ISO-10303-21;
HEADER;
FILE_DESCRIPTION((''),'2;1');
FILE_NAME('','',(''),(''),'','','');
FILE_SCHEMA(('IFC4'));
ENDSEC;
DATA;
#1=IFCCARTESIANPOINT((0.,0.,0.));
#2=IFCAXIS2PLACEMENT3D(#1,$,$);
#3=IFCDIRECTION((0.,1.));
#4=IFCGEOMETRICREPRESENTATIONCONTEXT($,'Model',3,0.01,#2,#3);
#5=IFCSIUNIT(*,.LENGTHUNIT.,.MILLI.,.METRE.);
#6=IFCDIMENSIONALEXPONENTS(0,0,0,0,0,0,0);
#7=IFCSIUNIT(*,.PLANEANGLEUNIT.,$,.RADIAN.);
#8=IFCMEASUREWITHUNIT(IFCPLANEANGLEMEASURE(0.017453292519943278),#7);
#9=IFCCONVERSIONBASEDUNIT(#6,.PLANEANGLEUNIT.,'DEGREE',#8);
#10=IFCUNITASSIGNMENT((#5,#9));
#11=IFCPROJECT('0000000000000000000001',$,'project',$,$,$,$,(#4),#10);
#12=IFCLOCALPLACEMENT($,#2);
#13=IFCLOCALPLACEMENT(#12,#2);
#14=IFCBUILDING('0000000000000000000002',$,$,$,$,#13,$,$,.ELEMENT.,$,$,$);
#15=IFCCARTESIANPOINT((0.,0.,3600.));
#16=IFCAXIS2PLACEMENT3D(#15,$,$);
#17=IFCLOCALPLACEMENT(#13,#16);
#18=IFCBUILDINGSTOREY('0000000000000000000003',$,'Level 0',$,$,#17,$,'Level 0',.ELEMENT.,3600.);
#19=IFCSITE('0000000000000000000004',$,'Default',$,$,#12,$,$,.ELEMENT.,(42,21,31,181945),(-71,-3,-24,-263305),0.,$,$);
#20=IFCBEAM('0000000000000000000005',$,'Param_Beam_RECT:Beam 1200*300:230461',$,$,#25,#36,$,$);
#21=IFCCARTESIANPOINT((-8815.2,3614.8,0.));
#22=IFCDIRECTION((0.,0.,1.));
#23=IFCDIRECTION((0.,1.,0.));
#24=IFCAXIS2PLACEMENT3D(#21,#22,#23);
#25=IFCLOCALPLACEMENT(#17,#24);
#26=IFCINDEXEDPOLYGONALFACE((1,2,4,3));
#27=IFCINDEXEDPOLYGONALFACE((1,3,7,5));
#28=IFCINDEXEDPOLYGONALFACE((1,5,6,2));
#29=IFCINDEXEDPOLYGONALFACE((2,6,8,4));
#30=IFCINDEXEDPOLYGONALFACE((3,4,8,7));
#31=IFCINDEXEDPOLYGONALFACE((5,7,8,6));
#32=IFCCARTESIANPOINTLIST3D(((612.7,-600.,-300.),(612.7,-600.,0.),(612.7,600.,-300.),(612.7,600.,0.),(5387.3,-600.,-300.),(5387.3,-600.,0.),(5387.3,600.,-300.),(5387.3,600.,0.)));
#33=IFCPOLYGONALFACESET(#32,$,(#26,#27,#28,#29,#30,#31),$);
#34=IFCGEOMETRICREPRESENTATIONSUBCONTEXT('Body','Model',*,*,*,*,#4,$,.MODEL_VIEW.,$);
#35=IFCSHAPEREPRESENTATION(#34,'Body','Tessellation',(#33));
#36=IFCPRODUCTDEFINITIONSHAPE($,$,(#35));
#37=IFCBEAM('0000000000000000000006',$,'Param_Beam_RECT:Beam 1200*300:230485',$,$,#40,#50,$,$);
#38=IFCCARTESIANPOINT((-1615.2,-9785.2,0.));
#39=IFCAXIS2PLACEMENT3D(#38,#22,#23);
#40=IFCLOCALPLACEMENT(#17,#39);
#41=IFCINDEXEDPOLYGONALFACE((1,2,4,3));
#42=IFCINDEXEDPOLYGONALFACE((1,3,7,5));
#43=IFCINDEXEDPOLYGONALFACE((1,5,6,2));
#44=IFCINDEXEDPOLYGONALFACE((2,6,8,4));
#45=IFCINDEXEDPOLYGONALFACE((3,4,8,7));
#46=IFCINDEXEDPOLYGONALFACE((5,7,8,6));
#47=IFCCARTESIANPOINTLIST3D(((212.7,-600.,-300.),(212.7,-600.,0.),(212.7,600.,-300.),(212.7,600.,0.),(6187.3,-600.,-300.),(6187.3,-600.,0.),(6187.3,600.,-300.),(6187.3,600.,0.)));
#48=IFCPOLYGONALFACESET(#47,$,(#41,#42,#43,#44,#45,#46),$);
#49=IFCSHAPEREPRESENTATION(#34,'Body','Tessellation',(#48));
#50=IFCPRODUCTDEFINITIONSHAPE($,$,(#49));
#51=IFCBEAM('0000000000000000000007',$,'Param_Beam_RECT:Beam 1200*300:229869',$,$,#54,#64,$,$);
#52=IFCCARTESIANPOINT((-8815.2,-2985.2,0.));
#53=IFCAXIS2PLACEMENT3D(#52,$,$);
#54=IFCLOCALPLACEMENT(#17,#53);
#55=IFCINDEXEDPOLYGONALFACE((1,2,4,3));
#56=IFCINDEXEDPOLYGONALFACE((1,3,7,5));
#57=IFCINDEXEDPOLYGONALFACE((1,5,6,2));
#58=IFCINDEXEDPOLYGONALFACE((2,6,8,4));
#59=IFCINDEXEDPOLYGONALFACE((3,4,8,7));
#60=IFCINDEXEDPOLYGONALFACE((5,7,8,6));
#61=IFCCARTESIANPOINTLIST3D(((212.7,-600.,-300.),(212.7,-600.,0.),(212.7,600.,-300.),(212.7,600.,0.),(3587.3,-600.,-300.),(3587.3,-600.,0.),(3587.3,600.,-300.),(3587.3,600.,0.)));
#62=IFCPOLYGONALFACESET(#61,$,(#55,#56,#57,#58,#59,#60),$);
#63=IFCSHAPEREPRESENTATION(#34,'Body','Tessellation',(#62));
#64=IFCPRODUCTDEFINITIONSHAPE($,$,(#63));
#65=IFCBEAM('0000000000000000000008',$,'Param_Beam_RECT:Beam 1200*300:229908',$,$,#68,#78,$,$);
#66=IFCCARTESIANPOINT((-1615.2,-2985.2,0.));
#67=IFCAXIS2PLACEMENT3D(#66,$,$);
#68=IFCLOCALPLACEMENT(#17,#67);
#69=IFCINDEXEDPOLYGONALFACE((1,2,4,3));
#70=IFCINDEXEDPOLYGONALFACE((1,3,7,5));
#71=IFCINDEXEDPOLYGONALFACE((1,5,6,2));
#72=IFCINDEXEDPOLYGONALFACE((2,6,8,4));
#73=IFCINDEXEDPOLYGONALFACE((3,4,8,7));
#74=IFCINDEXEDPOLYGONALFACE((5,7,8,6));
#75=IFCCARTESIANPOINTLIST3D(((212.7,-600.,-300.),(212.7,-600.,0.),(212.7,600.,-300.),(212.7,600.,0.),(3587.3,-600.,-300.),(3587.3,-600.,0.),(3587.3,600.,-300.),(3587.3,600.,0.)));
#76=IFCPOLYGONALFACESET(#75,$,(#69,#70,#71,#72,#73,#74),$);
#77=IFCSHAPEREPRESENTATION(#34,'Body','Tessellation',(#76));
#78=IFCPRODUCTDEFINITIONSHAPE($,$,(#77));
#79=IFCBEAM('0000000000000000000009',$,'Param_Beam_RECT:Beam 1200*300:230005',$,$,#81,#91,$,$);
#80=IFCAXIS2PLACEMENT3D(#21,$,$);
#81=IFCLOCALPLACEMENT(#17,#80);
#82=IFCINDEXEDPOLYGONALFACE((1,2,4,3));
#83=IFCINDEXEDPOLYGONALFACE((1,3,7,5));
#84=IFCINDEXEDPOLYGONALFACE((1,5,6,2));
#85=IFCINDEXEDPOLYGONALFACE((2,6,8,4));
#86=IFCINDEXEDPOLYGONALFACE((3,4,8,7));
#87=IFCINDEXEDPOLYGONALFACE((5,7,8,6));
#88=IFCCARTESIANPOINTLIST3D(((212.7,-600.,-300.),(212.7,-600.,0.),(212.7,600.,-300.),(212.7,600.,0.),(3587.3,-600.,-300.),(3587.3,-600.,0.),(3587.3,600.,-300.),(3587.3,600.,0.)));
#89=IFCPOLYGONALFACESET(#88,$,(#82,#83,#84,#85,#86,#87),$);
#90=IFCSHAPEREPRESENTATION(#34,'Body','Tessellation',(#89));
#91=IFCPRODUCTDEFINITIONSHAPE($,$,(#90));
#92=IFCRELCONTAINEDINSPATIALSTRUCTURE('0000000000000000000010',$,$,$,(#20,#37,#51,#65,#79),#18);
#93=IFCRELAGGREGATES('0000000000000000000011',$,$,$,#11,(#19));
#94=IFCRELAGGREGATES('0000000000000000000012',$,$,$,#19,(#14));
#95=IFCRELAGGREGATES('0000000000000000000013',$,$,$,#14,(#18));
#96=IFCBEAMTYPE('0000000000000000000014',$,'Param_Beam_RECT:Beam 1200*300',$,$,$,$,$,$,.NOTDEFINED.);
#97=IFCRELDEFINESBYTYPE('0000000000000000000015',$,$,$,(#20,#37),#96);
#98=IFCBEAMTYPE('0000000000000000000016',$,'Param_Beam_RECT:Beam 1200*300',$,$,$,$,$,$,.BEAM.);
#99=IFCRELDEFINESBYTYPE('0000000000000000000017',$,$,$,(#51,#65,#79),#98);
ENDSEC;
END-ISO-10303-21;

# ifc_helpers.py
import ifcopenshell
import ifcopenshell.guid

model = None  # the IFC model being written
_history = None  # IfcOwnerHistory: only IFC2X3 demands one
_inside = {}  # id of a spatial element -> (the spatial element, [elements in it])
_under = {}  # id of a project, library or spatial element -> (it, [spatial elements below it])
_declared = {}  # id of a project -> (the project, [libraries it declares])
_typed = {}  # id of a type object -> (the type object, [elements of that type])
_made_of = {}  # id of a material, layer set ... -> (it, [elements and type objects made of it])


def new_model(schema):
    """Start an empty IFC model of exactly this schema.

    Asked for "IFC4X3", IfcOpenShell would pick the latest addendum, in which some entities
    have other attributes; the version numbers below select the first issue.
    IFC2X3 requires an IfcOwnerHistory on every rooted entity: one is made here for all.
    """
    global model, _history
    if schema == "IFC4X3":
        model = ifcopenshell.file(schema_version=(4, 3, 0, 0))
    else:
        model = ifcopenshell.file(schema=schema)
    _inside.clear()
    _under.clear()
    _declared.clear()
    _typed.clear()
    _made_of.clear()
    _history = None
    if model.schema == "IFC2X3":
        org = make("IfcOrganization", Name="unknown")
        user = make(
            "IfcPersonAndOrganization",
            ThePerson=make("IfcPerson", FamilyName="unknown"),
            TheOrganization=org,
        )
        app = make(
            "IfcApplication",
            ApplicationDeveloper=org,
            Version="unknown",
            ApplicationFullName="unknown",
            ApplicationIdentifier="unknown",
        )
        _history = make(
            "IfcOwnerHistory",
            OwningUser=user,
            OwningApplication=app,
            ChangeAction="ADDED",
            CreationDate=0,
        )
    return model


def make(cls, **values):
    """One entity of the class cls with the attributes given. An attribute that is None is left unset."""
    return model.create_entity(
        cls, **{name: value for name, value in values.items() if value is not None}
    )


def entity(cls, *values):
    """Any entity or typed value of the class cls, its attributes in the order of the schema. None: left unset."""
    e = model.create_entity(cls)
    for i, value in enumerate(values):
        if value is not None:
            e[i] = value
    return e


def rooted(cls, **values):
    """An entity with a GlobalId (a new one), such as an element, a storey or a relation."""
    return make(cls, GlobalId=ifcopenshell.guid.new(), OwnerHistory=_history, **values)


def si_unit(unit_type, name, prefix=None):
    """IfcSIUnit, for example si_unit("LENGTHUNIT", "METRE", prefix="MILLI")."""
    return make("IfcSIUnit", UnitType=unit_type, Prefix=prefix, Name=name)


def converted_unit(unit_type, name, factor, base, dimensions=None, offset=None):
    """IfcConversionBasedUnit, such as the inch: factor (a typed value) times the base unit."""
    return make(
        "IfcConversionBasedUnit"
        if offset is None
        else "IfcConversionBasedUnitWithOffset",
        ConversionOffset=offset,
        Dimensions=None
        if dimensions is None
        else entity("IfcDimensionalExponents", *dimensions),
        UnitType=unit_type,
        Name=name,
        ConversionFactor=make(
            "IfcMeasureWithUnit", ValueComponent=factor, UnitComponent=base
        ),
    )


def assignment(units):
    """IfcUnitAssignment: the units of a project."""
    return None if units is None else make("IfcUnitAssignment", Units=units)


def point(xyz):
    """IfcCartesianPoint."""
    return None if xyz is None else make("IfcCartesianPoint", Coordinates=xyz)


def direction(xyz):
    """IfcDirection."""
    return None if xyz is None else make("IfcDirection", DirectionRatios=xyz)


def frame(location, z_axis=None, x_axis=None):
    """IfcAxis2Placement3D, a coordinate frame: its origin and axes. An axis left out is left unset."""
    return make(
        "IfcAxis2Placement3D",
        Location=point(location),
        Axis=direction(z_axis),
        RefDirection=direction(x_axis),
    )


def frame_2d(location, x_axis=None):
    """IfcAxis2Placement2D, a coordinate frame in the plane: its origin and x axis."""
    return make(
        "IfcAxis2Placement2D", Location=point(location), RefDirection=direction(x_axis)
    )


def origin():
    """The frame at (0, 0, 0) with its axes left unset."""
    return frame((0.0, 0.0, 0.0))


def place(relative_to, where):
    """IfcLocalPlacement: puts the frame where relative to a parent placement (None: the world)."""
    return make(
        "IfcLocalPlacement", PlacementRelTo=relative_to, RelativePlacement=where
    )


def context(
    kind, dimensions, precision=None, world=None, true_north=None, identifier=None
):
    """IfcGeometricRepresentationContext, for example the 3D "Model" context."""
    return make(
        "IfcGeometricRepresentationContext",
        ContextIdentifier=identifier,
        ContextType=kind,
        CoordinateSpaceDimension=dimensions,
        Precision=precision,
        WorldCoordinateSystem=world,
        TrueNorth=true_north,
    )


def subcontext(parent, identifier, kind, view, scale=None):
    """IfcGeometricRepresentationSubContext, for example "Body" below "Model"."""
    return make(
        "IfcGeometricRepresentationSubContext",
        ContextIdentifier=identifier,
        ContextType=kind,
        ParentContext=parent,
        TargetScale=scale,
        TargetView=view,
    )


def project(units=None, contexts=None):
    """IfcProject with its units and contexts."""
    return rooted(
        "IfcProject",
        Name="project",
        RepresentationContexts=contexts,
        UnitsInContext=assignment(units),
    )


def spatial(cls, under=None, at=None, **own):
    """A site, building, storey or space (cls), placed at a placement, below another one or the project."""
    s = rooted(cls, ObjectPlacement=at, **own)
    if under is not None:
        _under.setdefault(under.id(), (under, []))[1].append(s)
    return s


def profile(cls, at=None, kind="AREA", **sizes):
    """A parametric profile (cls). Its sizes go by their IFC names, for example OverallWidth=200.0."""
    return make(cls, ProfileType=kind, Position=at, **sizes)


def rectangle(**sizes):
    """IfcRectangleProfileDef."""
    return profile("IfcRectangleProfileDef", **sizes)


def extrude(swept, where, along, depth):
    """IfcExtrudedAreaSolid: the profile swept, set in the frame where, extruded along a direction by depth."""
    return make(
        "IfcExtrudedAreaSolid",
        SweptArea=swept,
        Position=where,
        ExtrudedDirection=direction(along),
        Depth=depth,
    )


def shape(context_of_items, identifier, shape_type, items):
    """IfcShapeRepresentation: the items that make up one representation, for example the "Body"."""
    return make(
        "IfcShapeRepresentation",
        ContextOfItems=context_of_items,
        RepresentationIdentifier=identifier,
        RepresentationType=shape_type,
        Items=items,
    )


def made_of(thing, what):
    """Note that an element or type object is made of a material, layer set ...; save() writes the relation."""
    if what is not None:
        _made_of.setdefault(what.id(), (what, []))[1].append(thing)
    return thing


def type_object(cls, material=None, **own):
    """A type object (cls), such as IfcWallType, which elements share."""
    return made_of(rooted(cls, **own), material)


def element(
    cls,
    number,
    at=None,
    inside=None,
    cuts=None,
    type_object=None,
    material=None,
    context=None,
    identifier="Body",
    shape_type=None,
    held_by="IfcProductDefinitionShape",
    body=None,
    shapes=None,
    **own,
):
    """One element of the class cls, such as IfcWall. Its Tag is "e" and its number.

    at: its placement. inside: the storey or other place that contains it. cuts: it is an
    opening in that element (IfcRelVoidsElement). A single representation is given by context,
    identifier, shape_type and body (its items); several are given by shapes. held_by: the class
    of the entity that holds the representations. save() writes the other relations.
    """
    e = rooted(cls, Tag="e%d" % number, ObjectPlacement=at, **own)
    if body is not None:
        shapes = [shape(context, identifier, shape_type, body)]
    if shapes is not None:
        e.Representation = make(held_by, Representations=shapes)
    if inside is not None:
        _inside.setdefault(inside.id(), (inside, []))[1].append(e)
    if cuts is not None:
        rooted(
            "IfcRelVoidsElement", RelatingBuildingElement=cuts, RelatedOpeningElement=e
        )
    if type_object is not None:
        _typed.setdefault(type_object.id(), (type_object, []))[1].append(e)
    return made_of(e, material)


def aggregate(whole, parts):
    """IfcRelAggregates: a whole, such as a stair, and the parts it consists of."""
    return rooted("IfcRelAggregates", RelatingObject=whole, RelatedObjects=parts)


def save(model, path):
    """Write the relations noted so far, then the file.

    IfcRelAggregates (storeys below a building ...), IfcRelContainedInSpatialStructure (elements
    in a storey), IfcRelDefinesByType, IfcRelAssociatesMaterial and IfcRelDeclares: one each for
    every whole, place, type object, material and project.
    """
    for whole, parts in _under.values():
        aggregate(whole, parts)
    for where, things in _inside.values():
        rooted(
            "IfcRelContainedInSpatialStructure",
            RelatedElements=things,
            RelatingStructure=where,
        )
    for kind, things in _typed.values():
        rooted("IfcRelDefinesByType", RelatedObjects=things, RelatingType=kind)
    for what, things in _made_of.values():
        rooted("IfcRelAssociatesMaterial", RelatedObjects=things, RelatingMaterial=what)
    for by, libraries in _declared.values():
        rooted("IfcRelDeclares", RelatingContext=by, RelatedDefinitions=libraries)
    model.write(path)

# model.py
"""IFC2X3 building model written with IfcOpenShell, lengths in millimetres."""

from ifc_helpers import new_model, entity, si_unit, converted_unit, direction, frame, frame_2d, origin, place, context, subcontext, project, spatial, rectangle, extrude, type_object, element, save


model = new_model("IFC2X3")

# Units and contexts
model_context = context("Model", 3, precision=0.01, world=origin(), true_north=direction((0.0, 1.0)))
body_context = subcontext(model_context, "Body", "Model", "MODEL_VIEW")
ifc_project = project(units=[si_unit("LENGTHUNIT", "METRE", prefix="MILLI"), converted_unit("PLANEANGLEUNIT", "DEGREE", entity("IfcPlaneAngleMeasure", 0.017453292519943278), si_unit("PLANEANGLEUNIT", "RADIAN"), dimensions=[0, 0, 0, 0, 0, 0, 0])], contexts=[model_context])

# Site, building, storey
site_placement = place(None, origin())
site = spatial("IfcSite", under=ifc_project, at=site_placement, Name="Default", CompositionType="ELEMENT", RefLatitude=(42, 21, 31, 181945), RefLongitude=(-71, -3, -24, -263305), RefElevation=0.0)
building_placement = place(site_placement, origin())
building = spatial("IfcBuilding", under=site, at=building_placement, CompositionType="ELEMENT")
storey_placement = place(building_placement, frame((0.0, 0.0, 3600.0)))
storey = spatial("IfcBuildingStorey", under=building, at=storey_placement, Name="Level 0", LongName="Level 0", CompositionType="ELEMENT", Elevation=3600.0)

# Beams
beam_type_1 = type_object("IfcBeamType", Name="Param_Beam_RECT:Beam 1200*300", PredefinedType="NOTDEFINED")
beam_1_placement = place(storey_placement, frame((-8815.2, 3614.8, 0.0), z_axis=(0.0, 0.0, 1.0), x_axis=(0.0, 1.0, 0.0)))
element("IfcBeam", 1, at=beam_1_placement, inside=storey, type_object=beam_type_1, Name="Param_Beam_RECT:Beam 1200*300:230461", context=body_context, shape_type="SweptSolid", body=[
    extrude(rectangle(XDim=300.0, YDim=1200.0, at=frame_2d((0.0, 0.0), x_axis=(1.0, 0.0))), frame((612.7, 0.0, -150.0), z_axis=(1.0, 0.0, 0.0), x_axis=(0.0, 0.0, -1.0)), (0.0, 0.0, 1.0), 4774.6),
])
beam_2_placement = place(storey_placement, frame((-1615.2, -9785.2, 0.0), z_axis=(0.0, 0.0, 1.0), x_axis=(0.0, 1.0, 0.0)))
element("IfcBeam", 2, at=beam_2_placement, inside=storey, type_object=beam_type_1, Name="Param_Beam_RECT:Beam 1200*300:230485", context=body_context, shape_type="SweptSolid", body=[
    extrude(rectangle(XDim=300.0, YDim=1200.0, at=frame_2d((0.0, 0.0), x_axis=(1.0, 0.0))), frame((212.7, 0.0, -150.0), z_axis=(1.0, 0.0, 0.0), x_axis=(0.0, 0.0, -1.0)), (0.0, 0.0, 1.0), 5974.6),
])
beam_type_2 = type_object("IfcBeamType", Name="Param_Beam_RECT:Beam 1200*300", PredefinedType="BEAM")
beam_3_placement = place(storey_placement, frame((-8815.2, -2985.2, 0.0)))
element("IfcBeam", 3, at=beam_3_placement, inside=storey, type_object=beam_type_2, Name="Param_Beam_RECT:Beam 1200*300:229869", context=body_context, shape_type="SweptSolid", body=[
    extrude(rectangle(XDim=300.0, YDim=1200.0, at=frame_2d((0.0, 0.0), x_axis=(1.0, 0.0))), frame((212.7, 0.0, -150.0), z_axis=(1.0, 0.0, 0.0), x_axis=(0.0, 0.0, -1.0)), (0.0, 0.0, 1.0), 3374.6),
])
beam_4_placement = place(storey_placement, frame((-1615.2, -2985.2, 0.0)))
element("IfcBeam", 4, at=beam_4_placement, inside=storey, type_object=beam_type_2, Name="Param_Beam_RECT:Beam 1200*300:229908", context=body_context, shape_type="SweptSolid", body=[
    extrude(rectangle(XDim=300.0, YDim=1200.0, at=frame_2d((0.0, 0.0), x_axis=(1.0, 0.0))), frame((212.7, 0.0, -150.0), z_axis=(1.0, 0.0, 0.0), x_axis=(0.0, 0.0, -1.0)), (0.0, 0.0, 1.0), 3374.6),
])
beam_5_placement = place(storey_placement, frame((-8815.2, 3614.8, 0.0)))
element("IfcBeam", 5, at=beam_5_placement, inside=storey, type_object=beam_type_2, Name="Param_Beam_RECT:Beam 1200*300:230005", context=body_context, shape_type="SweptSolid", body=[
    extrude(rectangle(XDim=300.0, YDim=1200.0, at=frame_2d((0.0, 0.0), x_axis=(1.0, 0.0))), frame((212.7, 0.0, -150.0), z_axis=(1.0, 0.0, 0.0), x_axis=(0.0, 0.0, -1.0)), (0.0, 0.0, 1.0), 3374.6),
])

save(model, "model.ifc")
